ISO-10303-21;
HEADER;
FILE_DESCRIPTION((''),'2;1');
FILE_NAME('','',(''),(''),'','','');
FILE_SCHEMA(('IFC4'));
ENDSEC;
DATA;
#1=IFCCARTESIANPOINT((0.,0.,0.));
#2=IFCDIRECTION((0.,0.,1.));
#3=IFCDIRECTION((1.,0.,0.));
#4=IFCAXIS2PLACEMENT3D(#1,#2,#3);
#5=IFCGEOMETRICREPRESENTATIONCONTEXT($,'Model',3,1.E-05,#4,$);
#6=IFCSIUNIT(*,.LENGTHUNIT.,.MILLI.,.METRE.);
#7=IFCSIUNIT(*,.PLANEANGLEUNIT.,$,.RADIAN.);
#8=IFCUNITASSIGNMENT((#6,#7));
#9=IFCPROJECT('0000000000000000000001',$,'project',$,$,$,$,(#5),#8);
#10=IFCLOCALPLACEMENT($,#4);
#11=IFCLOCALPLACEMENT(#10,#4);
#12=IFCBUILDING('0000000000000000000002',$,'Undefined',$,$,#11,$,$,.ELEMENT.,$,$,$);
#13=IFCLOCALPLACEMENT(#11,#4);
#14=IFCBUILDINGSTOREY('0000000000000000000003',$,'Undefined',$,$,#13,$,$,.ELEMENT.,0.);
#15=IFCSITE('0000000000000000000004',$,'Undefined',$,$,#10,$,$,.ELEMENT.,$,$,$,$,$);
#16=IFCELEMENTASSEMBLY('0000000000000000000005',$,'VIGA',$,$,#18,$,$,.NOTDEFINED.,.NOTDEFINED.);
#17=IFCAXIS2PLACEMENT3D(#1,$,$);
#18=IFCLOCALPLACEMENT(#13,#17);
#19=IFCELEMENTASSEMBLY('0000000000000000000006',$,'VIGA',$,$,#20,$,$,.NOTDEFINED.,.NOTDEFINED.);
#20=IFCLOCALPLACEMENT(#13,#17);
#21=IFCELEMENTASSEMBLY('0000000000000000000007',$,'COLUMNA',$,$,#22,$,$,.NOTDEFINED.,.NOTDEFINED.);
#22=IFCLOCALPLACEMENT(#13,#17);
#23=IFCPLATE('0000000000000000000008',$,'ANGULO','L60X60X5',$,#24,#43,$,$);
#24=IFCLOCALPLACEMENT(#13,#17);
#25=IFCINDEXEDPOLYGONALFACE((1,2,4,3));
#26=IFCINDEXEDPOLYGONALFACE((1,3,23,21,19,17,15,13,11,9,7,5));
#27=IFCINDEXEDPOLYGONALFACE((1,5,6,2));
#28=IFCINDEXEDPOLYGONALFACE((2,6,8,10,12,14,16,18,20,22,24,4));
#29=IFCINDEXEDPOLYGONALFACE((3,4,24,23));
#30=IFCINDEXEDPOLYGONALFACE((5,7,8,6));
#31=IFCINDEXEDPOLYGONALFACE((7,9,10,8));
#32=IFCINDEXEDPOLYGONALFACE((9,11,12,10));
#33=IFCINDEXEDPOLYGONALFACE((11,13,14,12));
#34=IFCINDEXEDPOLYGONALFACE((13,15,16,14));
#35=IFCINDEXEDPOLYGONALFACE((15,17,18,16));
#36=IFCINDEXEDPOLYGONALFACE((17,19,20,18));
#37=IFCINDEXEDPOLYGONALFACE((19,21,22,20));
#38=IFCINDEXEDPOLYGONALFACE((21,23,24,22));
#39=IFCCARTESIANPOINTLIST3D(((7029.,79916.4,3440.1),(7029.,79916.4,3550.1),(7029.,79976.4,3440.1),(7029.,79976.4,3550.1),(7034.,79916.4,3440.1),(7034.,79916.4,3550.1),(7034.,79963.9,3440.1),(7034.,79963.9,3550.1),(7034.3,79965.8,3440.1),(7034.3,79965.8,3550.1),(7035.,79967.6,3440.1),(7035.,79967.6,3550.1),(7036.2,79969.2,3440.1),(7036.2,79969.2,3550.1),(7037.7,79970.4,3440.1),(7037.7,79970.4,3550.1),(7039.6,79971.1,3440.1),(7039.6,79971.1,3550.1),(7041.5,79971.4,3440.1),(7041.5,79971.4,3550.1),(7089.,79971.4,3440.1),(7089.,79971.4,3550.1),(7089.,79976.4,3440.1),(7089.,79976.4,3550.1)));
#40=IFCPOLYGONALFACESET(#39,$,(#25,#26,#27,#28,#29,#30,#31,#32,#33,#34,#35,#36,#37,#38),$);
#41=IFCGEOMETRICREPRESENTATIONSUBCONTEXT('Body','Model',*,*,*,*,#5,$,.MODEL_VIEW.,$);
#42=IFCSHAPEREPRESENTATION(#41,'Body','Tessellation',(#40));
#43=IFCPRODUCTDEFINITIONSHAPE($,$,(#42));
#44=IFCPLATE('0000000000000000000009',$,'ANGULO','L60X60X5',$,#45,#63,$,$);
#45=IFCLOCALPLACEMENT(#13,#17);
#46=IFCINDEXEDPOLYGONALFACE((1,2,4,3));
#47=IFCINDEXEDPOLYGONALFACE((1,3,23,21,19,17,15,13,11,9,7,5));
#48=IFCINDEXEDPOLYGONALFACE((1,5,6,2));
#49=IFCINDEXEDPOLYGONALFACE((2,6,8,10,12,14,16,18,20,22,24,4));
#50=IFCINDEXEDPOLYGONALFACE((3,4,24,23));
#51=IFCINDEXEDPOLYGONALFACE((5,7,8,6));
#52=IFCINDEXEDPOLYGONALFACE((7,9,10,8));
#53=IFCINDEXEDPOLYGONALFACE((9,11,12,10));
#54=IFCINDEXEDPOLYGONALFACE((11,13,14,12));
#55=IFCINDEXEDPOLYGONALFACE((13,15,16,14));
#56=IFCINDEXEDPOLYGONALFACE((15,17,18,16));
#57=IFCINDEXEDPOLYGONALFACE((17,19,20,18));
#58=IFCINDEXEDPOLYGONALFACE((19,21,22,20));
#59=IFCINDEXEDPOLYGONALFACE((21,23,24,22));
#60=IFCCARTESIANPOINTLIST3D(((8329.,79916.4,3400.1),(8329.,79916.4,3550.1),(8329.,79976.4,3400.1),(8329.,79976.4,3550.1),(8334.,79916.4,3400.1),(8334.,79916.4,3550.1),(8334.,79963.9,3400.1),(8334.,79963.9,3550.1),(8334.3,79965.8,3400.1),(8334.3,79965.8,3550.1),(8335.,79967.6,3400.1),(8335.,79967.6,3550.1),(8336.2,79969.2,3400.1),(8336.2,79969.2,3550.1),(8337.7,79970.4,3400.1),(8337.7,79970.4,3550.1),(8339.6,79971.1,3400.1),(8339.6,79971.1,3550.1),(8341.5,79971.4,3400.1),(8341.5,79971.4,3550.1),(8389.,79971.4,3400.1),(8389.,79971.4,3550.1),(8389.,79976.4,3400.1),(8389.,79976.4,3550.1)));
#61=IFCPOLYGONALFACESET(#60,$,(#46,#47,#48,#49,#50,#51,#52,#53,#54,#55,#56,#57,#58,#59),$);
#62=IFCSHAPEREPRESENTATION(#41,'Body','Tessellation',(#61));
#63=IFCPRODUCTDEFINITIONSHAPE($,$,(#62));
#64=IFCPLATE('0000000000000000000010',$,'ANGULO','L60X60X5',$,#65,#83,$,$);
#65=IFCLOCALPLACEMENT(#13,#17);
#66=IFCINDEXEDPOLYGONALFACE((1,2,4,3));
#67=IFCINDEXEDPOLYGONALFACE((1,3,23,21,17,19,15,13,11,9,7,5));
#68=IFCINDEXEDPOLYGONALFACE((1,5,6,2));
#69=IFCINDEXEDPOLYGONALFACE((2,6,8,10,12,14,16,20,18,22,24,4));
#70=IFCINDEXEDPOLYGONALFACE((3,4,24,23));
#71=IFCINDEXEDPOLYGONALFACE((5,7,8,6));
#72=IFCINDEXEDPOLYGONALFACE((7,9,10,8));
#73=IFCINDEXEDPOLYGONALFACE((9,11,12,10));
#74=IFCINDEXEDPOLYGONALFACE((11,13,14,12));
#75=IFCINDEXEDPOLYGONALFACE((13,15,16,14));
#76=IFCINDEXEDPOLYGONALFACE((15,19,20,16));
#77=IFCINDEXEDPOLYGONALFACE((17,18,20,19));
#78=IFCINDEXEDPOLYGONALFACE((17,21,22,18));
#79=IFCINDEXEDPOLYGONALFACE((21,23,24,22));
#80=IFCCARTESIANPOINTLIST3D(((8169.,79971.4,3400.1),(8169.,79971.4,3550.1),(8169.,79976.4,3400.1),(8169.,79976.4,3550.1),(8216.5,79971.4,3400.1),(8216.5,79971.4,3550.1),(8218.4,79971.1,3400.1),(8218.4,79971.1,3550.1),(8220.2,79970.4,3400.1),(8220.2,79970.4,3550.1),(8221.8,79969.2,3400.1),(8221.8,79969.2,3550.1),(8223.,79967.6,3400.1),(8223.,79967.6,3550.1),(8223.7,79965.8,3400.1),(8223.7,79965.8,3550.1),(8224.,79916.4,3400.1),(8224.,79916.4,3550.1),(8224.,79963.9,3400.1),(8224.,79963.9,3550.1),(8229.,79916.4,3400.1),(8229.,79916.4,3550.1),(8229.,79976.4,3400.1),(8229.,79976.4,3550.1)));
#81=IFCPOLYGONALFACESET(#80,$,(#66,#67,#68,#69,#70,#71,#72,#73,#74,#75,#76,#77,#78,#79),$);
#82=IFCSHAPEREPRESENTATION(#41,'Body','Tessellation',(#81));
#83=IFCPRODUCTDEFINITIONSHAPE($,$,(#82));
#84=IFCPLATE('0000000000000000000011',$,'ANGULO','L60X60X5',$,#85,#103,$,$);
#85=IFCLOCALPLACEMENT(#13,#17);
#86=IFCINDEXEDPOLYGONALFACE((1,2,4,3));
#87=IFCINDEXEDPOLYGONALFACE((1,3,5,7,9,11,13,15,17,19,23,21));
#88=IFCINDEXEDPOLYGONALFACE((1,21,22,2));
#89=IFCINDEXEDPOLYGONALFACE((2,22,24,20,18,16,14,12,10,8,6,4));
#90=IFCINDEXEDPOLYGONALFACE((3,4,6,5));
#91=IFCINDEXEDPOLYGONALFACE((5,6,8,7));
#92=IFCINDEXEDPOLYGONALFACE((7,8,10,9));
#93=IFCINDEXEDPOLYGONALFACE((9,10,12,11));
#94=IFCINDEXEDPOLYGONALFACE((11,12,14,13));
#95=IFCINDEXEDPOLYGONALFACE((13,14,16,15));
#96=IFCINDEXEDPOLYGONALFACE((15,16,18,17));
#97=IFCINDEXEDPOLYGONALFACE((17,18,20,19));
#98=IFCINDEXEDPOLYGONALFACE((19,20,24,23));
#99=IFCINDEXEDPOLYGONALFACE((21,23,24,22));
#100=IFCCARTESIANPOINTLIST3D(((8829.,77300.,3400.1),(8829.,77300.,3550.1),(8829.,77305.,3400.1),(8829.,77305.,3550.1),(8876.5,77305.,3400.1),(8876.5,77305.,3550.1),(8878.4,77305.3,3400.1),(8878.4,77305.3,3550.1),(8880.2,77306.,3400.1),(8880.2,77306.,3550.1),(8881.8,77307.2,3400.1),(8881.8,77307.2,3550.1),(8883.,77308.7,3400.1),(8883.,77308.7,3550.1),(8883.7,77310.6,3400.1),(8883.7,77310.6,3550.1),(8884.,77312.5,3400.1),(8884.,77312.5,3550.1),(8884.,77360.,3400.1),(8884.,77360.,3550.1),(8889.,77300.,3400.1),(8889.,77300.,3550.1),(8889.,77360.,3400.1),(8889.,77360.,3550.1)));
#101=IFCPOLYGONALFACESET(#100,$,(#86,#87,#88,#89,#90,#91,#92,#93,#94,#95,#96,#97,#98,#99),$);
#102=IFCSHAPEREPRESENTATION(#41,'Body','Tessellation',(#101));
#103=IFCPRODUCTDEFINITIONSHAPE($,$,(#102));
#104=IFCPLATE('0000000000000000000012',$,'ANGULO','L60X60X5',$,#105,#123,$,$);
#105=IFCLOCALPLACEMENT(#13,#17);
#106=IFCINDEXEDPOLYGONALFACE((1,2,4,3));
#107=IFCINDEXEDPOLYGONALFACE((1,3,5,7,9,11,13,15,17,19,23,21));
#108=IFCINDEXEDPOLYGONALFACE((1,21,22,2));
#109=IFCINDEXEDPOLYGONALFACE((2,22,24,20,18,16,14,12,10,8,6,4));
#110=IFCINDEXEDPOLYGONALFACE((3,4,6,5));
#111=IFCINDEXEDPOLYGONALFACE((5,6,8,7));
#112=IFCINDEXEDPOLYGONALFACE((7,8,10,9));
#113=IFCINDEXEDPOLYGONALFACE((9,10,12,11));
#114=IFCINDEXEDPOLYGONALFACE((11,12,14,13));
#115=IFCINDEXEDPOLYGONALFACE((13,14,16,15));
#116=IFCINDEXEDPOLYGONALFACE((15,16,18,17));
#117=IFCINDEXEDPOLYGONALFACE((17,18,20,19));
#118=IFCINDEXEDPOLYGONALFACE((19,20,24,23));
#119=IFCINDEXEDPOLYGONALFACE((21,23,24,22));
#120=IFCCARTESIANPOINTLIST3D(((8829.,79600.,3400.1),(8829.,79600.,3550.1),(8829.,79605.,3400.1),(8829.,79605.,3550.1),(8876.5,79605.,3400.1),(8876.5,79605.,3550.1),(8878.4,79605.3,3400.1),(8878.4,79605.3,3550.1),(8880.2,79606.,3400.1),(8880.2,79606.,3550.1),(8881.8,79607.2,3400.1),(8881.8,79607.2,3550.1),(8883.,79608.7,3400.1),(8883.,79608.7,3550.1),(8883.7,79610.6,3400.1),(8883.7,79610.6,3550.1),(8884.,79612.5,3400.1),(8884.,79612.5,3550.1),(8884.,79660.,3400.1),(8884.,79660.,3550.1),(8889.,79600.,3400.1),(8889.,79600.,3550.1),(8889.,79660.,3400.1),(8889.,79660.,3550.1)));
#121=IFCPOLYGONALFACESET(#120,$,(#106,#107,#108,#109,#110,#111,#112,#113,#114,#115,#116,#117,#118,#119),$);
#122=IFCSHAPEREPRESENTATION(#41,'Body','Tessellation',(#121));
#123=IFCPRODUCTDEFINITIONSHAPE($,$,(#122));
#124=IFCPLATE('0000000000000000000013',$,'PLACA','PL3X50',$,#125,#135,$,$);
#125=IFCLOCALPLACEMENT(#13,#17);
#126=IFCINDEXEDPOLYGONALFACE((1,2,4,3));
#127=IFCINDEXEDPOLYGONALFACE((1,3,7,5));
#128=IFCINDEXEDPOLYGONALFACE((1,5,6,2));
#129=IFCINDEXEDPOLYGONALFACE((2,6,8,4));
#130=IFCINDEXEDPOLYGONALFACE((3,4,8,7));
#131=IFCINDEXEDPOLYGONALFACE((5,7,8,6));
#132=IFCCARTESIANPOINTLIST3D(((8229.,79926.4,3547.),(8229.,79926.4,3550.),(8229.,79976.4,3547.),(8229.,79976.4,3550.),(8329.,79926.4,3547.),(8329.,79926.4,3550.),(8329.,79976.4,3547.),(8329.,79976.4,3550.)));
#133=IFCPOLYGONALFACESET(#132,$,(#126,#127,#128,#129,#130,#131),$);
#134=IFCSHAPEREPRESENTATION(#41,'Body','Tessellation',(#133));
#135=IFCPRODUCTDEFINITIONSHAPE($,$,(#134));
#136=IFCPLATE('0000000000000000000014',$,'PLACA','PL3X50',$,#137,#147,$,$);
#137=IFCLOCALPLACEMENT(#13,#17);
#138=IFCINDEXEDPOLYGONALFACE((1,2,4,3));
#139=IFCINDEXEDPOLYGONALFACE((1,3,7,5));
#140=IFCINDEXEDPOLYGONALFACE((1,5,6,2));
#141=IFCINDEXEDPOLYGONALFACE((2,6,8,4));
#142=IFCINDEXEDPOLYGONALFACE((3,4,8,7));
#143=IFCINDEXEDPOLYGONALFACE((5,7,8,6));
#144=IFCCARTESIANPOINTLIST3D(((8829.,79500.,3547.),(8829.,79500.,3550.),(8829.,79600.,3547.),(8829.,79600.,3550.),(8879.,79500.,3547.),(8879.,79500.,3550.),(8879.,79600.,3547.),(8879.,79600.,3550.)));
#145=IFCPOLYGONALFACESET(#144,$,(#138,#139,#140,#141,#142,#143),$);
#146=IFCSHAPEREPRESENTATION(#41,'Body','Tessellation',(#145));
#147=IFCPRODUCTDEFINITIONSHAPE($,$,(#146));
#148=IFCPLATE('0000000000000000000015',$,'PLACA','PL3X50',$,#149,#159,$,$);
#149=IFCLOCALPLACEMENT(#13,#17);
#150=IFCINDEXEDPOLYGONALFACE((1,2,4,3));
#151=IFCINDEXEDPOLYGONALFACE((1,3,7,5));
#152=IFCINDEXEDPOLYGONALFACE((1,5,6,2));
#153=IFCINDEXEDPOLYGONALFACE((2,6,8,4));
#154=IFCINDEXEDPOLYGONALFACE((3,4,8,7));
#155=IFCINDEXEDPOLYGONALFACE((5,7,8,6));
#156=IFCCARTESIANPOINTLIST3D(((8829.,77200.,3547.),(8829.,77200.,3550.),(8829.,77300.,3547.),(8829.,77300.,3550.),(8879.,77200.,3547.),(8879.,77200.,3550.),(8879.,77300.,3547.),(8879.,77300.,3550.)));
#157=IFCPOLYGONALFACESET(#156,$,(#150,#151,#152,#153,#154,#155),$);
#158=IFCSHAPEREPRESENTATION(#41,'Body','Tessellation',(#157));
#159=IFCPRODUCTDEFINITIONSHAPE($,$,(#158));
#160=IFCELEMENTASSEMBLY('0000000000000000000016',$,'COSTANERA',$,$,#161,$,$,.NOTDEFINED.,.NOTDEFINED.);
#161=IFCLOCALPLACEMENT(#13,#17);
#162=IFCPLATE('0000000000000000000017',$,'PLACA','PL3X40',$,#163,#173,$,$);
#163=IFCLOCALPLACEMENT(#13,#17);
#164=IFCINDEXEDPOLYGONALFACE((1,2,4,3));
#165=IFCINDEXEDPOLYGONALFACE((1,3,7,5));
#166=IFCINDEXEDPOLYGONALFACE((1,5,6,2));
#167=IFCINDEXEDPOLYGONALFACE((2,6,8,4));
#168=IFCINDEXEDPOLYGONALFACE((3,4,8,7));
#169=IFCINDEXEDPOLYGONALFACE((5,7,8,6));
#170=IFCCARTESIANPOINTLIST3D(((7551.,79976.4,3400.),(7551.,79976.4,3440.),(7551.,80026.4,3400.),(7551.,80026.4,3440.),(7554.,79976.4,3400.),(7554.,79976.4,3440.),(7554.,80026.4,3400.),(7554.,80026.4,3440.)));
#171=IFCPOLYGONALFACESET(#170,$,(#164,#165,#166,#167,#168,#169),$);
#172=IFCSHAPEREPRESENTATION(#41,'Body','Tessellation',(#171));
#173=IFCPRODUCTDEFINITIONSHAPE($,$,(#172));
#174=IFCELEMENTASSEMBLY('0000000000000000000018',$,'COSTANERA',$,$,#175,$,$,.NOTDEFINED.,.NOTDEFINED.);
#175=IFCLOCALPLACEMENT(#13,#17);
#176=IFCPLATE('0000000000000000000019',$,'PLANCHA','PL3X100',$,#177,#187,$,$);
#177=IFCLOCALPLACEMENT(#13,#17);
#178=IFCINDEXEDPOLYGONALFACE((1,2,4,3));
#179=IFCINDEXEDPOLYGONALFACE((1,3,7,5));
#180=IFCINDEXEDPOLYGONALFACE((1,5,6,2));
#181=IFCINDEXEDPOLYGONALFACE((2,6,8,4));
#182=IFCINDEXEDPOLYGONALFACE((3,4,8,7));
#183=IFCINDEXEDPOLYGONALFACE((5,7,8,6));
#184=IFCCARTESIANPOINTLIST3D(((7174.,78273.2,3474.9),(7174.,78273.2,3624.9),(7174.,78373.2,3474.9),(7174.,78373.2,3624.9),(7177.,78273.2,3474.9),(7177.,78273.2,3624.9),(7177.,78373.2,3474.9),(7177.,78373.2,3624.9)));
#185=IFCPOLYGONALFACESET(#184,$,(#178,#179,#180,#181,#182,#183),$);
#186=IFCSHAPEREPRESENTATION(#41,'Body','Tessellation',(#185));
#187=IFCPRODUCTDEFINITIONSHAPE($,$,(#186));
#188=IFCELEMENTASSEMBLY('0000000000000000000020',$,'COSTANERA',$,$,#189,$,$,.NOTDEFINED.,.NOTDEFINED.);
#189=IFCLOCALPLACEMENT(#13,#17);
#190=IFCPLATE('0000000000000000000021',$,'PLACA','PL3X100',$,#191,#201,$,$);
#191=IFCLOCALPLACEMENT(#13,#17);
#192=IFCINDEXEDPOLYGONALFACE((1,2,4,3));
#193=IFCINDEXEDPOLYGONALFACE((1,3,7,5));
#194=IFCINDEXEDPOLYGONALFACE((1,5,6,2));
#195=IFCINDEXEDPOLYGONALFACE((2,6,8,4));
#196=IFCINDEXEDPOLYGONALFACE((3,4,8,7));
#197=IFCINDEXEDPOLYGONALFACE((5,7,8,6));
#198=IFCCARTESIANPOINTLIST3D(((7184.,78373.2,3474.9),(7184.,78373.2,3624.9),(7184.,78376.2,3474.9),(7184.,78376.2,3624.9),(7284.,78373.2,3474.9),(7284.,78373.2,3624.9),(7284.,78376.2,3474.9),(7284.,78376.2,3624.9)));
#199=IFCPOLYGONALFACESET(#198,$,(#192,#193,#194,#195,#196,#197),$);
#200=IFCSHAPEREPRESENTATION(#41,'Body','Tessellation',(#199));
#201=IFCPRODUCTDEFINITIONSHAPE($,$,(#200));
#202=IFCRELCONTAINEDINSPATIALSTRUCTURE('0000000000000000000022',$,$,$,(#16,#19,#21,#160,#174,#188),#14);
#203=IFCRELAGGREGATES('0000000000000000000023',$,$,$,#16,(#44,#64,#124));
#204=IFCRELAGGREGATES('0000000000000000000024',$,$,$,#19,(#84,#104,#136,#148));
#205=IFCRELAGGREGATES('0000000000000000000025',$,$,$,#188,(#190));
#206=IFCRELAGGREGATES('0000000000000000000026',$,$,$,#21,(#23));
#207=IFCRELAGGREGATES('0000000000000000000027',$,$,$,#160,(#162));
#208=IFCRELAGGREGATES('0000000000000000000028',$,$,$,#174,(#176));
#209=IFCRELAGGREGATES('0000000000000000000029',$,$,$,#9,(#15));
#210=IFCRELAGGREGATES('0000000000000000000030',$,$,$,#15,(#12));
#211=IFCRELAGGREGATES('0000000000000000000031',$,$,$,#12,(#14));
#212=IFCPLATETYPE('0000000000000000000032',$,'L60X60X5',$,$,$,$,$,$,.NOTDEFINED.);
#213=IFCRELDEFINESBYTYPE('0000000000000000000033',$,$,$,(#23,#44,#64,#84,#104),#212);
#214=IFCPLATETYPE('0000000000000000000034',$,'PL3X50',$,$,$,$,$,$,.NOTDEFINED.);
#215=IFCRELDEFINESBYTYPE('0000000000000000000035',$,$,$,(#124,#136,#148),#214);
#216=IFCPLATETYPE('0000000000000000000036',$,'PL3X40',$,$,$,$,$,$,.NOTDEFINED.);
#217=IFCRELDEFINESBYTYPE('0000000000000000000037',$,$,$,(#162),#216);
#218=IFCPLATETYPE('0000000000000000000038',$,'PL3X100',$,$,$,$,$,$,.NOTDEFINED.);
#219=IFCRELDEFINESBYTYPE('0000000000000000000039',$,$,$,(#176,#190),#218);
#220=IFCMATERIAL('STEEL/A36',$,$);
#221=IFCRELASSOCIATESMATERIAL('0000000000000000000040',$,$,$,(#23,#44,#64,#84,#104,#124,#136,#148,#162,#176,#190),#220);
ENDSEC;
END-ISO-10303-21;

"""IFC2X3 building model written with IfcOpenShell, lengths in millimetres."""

from ifc_helpers import new_model, si_unit, frame, origin_with_axes, origin_2d_with_axis, place, context, subcontext, project, spatial, polyline, l_section, outline, extrude, material, type_object, element, aggregate, save


model = new_model("IFC2X3")

# Units and contexts
model_context = context("Model", 3, precision=1e-05, world=origin_with_axes())
body_context = subcontext(model_context, "Body", "Model", "MODEL_VIEW")
ifc_project = project(units=[si_unit("LENGTHUNIT", "METRE", prefix="MILLI"), si_unit("PLANEANGLEUNIT", "RADIAN")], contexts=[model_context])

# Site, building, storey
site_placement = place(None, origin_with_axes())
site = spatial("IfcSite", under=ifc_project, at=site_placement, Name="Undefined", CompositionType="ELEMENT")
building_placement = place(site_placement, origin_with_axes())
building = spatial("IfcBuilding", under=site, at=building_placement, Name="Undefined", CompositionType="ELEMENT")
storey_placement = place(building_placement, origin_with_axes())
storey = spatial("IfcBuildingStorey", under=building, at=storey_placement, Name="Undefined", CompositionType="ELEMENT", Elevation=0.0)

# Element assembly
assembly_1_placement = place(storey_placement, origin_with_axes())
assembly_1 = element("IfcElementAssembly", 1, at=assembly_1_placement, inside=storey, Name="VIGA", AssemblyPlace="NOTDEFINED", PredefinedType="NOTDEFINED")
ifc_material_1 = material(Name="STEEL/A36")

# Element assembly
assembly_2_placement = place(storey_placement, origin_with_axes())
assembly_2 = element("IfcElementAssembly", 2, at=assembly_2_placement, inside=storey, Name="VIGA", AssemblyPlace="NOTDEFINED", PredefinedType="NOTDEFINED")

# Element assembly, plate
assembly_3_placement = place(storey_placement, origin_with_axes())
assembly_3 = element("IfcElementAssembly", 3, at=assembly_3_placement, inside=storey, Name="COLUMNA", AssemblyPlace="NOTDEFINED", PredefinedType="NOTDEFINED")
plate_type_1 = type_object("IfcPlateType", Name="L60X60X5", PredefinedType="NOTDEFINED")
plate_1_placement = place(assembly_3_placement, frame((7059.0, 79946.4, 3440.1), z_axis=(0.0, -1.0, 0.0), x_axis=(0.0, 0.0, 1.0)))
plate_1 = element("IfcPlate", 4, at=plate_1_placement, type_object=plate_type_1, material=ifc_material_1, Name="ANGULO", Description="L60X60X5", context=body_context, shape_type="SweptSolid", body=[
    extrude(l_section(Depth=60.0, Width=60.0, Thickness=5.0, FilletRadius=7.5, at=origin_2d_with_axis()), frame((110.0, 0.0, 0.0), z_axis=(-1.0, 0.0, 0.0), x_axis=(0.0, -1.0, 0.0)), (0.0, 0.0, 1.0), 110.0),
])

# Plates
plate_2_placement = place(assembly_1_placement, frame((8359.0, 79946.4, 3400.1), z_axis=(0.0, -1.0, 0.0), x_axis=(0.0, 0.0, 1.0)))
plate_2 = element("IfcPlate", 5, at=plate_2_placement, type_object=plate_type_1, material=ifc_material_1, Name="ANGULO", Description="L60X60X5", context=body_context, shape_type="SweptSolid", body=[
    extrude(l_section(Depth=60.0, Width=60.0, Thickness=5.0, FilletRadius=7.5, at=origin_2d_with_axis()), frame((150.0, 0.0, 0.0), z_axis=(-1.0, 0.0, 0.0), x_axis=(0.0, -1.0, 0.0)), (0.0, 0.0, 1.0), 150.0),
])
plate_3_placement = place(assembly_1_placement, frame((8199.0, 79946.4, 3550.1), z_axis=(0.0, -1.0, 0.0), x_axis=(0.0, 0.0, -1.0)))
plate_3 = element("IfcPlate", 6, at=plate_3_placement, type_object=plate_type_1, material=ifc_material_1, Name="ANGULO", Description="L60X60X5", context=body_context, shape_type="SweptSolid", body=[
    extrude(l_section(Depth=60.0, Width=60.0, Thickness=5.0, FilletRadius=7.5, at=origin_2d_with_axis()), frame((150.0, 0.0, 0.0), z_axis=(-1.0, 0.0, 0.0), x_axis=(0.0, -1.0, 0.0)), (0.0, 0.0, 1.0), 150.0),
])
plate_4_placement = place(assembly_2_placement, frame((8859.0, 77330.0, 3550.1), z_axis=(-1.0, 0.0, 0.0), x_axis=(0.0, 0.0, -1.0)))
plate_4 = element("IfcPlate", 7, at=plate_4_placement, type_object=plate_type_1, material=ifc_material_1, Name="ANGULO", Description="L60X60X5", context=body_context, shape_type="SweptSolid", body=[
    extrude(l_section(Depth=60.0, Width=60.0, Thickness=5.0, FilletRadius=7.5, at=origin_2d_with_axis()), frame((150.0, 0.0, 0.0), z_axis=(-1.0, 0.0, 0.0), x_axis=(0.0, -1.0, 0.0)), (0.0, 0.0, 1.0), 150.0),
])
plate_5_placement = place(assembly_2_placement, frame((8859.0, 79630.0, 3550.1), z_axis=(-1.0, 0.0, 0.0), x_axis=(0.0, 0.0, -1.0)))
plate_5 = element("IfcPlate", 8, at=plate_5_placement, type_object=plate_type_1, material=ifc_material_1, Name="ANGULO", Description="L60X60X5", context=body_context, shape_type="SweptSolid", body=[
    extrude(l_section(Depth=60.0, Width=60.0, Thickness=5.0, FilletRadius=7.5, at=origin_2d_with_axis()), frame((150.0, 0.0, 0.0), z_axis=(-1.0, 0.0, 0.0), x_axis=(0.0, -1.0, 0.0)), (0.0, 0.0, 1.0), 150.0),
])
plate_type_2 = type_object("IfcPlateType", Name="PL3X50", PredefinedType="NOTDEFINED")
plate_6_placement = place(assembly_1_placement, frame((8229.0, 79926.4, 3548.5), z_axis=(0.0, 0.0, -1.0), x_axis=(0.0, 1.0, 0.0)))
plate_6 = element("IfcPlate", 9, at=plate_6_placement, type_object=plate_type_2, material=ifc_material_1, Name="PLACA", Description="PL3X50", context=body_context, shape_type="SweptSolid", body=[
    extrude(outline(polyline([(0.0, 0.0), (50.0, 0.0), (50.0, 100.0), (0.0, 100.0), (0.0, 0.0)])), frame((0.0, 0.0, -1.5), z_axis=(0.0, 0.0, 1.0), x_axis=(1.0, 0.0, 0.0)), (0.0, 0.0, 1.0), 3.0),
])
aggregate(assembly_1, [plate_2, plate_3, plate_6])
plate_7_placement = place(assembly_2_placement, frame((8879.0, 79500.0, 3548.5), z_axis=(0.0, 0.0, -1.0), x_axis=(-1.0, 0.0, 0.0)))
plate_7 = element("IfcPlate", 10, at=plate_7_placement, type_object=plate_type_2, material=ifc_material_1, Name="PLACA", Description="PL3X50", context=body_context, shape_type="SweptSolid", body=[
    extrude(outline(polyline([(0.0, 0.0), (50.0, 0.0), (50.0, 100.0), (0.0, 100.0), (0.0, 0.0)])), frame((0.0, 0.0, -1.5), z_axis=(0.0, 0.0, 1.0), x_axis=(1.0, 0.0, 0.0)), (0.0, 0.0, 1.0), 3.0),
])
plate_8_placement = place(assembly_2_placement, frame((8879.0, 77200.0, 3548.5), z_axis=(0.0, 0.0, -1.0), x_axis=(-1.0, 0.0, 0.0)))
plate_8 = element("IfcPlate", 11, at=plate_8_placement, type_object=plate_type_2, material=ifc_material_1, Name="PLACA", Description="PL3X50", context=body_context, shape_type="SweptSolid", body=[
    extrude(outline(polyline([(0.0, 0.0), (50.0, 0.0), (50.0, 100.0), (0.0, 100.0), (0.0, 0.0)])), frame((0.0, 0.0, -1.5), z_axis=(0.0, 0.0, 1.0), x_axis=(1.0, 0.0, 0.0)), (0.0, 0.0, 1.0), 3.0),
])
aggregate(assembly_2, [plate_4, plate_5, plate_7, plate_8])

# Element assemblies, plates
assembly_4_placement = place(storey_placement, origin_with_axes())
assembly_4 = element("IfcElementAssembly", 12, at=assembly_4_placement, inside=storey, Name="COSTANERA", AssemblyPlace="NOTDEFINED", PredefinedType="NOTDEFINED")
plate_type_3 = type_object("IfcPlateType", Name="PL3X40", PredefinedType="NOTDEFINED")
plate_9_placement = place(assembly_4_placement, frame((7552.5, 79976.4, 3440.0), z_axis=(1.0, 0.0, 0.0), x_axis=(0.0, 0.0, -1.0)))
plate_9 = element("IfcPlate", 13, at=plate_9_placement, type_object=plate_type_3, material=ifc_material_1, Name="PLACA", Description="PL3X40", context=body_context, shape_type="SweptSolid", body=[
    extrude(outline(polyline([(0.0, 0.0), (40.0, 0.0), (40.0, 50.0), (0.0, 50.0), (0.0, 0.0)])), frame((0.0, 0.0, -1.5), z_axis=(0.0, 0.0, 1.0), x_axis=(1.0, 0.0, 0.0)), (0.0, 0.0, 1.0), 3.0),
])
assembly_5_placement = place(storey_placement, origin_with_axes())
assembly_5 = element("IfcElementAssembly", 14, at=assembly_5_placement, inside=storey, Name="COSTANERA", AssemblyPlace="NOTDEFINED", PredefinedType="NOTDEFINED")
plate_type_4 = type_object("IfcPlateType", Name="PL3X100", PredefinedType="NOTDEFINED")
plate_10_placement = place(assembly_5_placement, frame((7175.5, 78373.2, 3474.9), z_axis=(-1.0, 0.0, 0.0), x_axis=(0.0, -1.0, 0.0)))
plate_10 = element("IfcPlate", 15, at=plate_10_placement, type_object=plate_type_4, material=ifc_material_1, Name="PLANCHA", Description="PL3X100", context=body_context, shape_type="SweptSolid", body=[
    extrude(outline(polyline([(0.0, 0.0), (100.0, 0.0), (100.0, 150.0), (0.0, 150.0), (0.0, 0.0)])), frame((0.0, 0.0, -1.5), z_axis=(0.0, 0.0, 1.0), x_axis=(1.0, 0.0, 0.0)), (0.0, 0.0, 1.0), 3.0),
])
assembly_6_placement = place(storey_placement, origin_with_axes())
assembly_6 = element("IfcElementAssembly", 16, at=assembly_6_placement, inside=storey, Name="COSTANERA", AssemblyPlace="NOTDEFINED", PredefinedType="NOTDEFINED")
plate_11_placement = place(assembly_6_placement, frame((7184.0, 78374.7, 3474.9), z_axis=(0.0, -1.0, 0.0), x_axis=(1.0, 0.0, 0.0)))
plate_11 = element("IfcPlate", 17, at=plate_11_placement, type_object=plate_type_4, material=ifc_material_1, Name="PLACA", Description="PL3X100", context=body_context, shape_type="SweptSolid", body=[
    extrude(outline(polyline([(0.0, 0.0), (100.0, 0.0), (100.0, 150.0), (0.0, 150.0), (0.0, 0.0)])), frame((0.0, 0.0, -1.5), z_axis=(0.0, 0.0, 1.0), x_axis=(1.0, 0.0, 0.0)), (0.0, 0.0, 1.0), 3.0),
])
aggregate(assembly_6, [plate_11])

aggregate(assembly_3, [plate_1])

aggregate(assembly_4, [plate_9])

aggregate(assembly_5, [plate_10])

save(model, "model.ifc")
